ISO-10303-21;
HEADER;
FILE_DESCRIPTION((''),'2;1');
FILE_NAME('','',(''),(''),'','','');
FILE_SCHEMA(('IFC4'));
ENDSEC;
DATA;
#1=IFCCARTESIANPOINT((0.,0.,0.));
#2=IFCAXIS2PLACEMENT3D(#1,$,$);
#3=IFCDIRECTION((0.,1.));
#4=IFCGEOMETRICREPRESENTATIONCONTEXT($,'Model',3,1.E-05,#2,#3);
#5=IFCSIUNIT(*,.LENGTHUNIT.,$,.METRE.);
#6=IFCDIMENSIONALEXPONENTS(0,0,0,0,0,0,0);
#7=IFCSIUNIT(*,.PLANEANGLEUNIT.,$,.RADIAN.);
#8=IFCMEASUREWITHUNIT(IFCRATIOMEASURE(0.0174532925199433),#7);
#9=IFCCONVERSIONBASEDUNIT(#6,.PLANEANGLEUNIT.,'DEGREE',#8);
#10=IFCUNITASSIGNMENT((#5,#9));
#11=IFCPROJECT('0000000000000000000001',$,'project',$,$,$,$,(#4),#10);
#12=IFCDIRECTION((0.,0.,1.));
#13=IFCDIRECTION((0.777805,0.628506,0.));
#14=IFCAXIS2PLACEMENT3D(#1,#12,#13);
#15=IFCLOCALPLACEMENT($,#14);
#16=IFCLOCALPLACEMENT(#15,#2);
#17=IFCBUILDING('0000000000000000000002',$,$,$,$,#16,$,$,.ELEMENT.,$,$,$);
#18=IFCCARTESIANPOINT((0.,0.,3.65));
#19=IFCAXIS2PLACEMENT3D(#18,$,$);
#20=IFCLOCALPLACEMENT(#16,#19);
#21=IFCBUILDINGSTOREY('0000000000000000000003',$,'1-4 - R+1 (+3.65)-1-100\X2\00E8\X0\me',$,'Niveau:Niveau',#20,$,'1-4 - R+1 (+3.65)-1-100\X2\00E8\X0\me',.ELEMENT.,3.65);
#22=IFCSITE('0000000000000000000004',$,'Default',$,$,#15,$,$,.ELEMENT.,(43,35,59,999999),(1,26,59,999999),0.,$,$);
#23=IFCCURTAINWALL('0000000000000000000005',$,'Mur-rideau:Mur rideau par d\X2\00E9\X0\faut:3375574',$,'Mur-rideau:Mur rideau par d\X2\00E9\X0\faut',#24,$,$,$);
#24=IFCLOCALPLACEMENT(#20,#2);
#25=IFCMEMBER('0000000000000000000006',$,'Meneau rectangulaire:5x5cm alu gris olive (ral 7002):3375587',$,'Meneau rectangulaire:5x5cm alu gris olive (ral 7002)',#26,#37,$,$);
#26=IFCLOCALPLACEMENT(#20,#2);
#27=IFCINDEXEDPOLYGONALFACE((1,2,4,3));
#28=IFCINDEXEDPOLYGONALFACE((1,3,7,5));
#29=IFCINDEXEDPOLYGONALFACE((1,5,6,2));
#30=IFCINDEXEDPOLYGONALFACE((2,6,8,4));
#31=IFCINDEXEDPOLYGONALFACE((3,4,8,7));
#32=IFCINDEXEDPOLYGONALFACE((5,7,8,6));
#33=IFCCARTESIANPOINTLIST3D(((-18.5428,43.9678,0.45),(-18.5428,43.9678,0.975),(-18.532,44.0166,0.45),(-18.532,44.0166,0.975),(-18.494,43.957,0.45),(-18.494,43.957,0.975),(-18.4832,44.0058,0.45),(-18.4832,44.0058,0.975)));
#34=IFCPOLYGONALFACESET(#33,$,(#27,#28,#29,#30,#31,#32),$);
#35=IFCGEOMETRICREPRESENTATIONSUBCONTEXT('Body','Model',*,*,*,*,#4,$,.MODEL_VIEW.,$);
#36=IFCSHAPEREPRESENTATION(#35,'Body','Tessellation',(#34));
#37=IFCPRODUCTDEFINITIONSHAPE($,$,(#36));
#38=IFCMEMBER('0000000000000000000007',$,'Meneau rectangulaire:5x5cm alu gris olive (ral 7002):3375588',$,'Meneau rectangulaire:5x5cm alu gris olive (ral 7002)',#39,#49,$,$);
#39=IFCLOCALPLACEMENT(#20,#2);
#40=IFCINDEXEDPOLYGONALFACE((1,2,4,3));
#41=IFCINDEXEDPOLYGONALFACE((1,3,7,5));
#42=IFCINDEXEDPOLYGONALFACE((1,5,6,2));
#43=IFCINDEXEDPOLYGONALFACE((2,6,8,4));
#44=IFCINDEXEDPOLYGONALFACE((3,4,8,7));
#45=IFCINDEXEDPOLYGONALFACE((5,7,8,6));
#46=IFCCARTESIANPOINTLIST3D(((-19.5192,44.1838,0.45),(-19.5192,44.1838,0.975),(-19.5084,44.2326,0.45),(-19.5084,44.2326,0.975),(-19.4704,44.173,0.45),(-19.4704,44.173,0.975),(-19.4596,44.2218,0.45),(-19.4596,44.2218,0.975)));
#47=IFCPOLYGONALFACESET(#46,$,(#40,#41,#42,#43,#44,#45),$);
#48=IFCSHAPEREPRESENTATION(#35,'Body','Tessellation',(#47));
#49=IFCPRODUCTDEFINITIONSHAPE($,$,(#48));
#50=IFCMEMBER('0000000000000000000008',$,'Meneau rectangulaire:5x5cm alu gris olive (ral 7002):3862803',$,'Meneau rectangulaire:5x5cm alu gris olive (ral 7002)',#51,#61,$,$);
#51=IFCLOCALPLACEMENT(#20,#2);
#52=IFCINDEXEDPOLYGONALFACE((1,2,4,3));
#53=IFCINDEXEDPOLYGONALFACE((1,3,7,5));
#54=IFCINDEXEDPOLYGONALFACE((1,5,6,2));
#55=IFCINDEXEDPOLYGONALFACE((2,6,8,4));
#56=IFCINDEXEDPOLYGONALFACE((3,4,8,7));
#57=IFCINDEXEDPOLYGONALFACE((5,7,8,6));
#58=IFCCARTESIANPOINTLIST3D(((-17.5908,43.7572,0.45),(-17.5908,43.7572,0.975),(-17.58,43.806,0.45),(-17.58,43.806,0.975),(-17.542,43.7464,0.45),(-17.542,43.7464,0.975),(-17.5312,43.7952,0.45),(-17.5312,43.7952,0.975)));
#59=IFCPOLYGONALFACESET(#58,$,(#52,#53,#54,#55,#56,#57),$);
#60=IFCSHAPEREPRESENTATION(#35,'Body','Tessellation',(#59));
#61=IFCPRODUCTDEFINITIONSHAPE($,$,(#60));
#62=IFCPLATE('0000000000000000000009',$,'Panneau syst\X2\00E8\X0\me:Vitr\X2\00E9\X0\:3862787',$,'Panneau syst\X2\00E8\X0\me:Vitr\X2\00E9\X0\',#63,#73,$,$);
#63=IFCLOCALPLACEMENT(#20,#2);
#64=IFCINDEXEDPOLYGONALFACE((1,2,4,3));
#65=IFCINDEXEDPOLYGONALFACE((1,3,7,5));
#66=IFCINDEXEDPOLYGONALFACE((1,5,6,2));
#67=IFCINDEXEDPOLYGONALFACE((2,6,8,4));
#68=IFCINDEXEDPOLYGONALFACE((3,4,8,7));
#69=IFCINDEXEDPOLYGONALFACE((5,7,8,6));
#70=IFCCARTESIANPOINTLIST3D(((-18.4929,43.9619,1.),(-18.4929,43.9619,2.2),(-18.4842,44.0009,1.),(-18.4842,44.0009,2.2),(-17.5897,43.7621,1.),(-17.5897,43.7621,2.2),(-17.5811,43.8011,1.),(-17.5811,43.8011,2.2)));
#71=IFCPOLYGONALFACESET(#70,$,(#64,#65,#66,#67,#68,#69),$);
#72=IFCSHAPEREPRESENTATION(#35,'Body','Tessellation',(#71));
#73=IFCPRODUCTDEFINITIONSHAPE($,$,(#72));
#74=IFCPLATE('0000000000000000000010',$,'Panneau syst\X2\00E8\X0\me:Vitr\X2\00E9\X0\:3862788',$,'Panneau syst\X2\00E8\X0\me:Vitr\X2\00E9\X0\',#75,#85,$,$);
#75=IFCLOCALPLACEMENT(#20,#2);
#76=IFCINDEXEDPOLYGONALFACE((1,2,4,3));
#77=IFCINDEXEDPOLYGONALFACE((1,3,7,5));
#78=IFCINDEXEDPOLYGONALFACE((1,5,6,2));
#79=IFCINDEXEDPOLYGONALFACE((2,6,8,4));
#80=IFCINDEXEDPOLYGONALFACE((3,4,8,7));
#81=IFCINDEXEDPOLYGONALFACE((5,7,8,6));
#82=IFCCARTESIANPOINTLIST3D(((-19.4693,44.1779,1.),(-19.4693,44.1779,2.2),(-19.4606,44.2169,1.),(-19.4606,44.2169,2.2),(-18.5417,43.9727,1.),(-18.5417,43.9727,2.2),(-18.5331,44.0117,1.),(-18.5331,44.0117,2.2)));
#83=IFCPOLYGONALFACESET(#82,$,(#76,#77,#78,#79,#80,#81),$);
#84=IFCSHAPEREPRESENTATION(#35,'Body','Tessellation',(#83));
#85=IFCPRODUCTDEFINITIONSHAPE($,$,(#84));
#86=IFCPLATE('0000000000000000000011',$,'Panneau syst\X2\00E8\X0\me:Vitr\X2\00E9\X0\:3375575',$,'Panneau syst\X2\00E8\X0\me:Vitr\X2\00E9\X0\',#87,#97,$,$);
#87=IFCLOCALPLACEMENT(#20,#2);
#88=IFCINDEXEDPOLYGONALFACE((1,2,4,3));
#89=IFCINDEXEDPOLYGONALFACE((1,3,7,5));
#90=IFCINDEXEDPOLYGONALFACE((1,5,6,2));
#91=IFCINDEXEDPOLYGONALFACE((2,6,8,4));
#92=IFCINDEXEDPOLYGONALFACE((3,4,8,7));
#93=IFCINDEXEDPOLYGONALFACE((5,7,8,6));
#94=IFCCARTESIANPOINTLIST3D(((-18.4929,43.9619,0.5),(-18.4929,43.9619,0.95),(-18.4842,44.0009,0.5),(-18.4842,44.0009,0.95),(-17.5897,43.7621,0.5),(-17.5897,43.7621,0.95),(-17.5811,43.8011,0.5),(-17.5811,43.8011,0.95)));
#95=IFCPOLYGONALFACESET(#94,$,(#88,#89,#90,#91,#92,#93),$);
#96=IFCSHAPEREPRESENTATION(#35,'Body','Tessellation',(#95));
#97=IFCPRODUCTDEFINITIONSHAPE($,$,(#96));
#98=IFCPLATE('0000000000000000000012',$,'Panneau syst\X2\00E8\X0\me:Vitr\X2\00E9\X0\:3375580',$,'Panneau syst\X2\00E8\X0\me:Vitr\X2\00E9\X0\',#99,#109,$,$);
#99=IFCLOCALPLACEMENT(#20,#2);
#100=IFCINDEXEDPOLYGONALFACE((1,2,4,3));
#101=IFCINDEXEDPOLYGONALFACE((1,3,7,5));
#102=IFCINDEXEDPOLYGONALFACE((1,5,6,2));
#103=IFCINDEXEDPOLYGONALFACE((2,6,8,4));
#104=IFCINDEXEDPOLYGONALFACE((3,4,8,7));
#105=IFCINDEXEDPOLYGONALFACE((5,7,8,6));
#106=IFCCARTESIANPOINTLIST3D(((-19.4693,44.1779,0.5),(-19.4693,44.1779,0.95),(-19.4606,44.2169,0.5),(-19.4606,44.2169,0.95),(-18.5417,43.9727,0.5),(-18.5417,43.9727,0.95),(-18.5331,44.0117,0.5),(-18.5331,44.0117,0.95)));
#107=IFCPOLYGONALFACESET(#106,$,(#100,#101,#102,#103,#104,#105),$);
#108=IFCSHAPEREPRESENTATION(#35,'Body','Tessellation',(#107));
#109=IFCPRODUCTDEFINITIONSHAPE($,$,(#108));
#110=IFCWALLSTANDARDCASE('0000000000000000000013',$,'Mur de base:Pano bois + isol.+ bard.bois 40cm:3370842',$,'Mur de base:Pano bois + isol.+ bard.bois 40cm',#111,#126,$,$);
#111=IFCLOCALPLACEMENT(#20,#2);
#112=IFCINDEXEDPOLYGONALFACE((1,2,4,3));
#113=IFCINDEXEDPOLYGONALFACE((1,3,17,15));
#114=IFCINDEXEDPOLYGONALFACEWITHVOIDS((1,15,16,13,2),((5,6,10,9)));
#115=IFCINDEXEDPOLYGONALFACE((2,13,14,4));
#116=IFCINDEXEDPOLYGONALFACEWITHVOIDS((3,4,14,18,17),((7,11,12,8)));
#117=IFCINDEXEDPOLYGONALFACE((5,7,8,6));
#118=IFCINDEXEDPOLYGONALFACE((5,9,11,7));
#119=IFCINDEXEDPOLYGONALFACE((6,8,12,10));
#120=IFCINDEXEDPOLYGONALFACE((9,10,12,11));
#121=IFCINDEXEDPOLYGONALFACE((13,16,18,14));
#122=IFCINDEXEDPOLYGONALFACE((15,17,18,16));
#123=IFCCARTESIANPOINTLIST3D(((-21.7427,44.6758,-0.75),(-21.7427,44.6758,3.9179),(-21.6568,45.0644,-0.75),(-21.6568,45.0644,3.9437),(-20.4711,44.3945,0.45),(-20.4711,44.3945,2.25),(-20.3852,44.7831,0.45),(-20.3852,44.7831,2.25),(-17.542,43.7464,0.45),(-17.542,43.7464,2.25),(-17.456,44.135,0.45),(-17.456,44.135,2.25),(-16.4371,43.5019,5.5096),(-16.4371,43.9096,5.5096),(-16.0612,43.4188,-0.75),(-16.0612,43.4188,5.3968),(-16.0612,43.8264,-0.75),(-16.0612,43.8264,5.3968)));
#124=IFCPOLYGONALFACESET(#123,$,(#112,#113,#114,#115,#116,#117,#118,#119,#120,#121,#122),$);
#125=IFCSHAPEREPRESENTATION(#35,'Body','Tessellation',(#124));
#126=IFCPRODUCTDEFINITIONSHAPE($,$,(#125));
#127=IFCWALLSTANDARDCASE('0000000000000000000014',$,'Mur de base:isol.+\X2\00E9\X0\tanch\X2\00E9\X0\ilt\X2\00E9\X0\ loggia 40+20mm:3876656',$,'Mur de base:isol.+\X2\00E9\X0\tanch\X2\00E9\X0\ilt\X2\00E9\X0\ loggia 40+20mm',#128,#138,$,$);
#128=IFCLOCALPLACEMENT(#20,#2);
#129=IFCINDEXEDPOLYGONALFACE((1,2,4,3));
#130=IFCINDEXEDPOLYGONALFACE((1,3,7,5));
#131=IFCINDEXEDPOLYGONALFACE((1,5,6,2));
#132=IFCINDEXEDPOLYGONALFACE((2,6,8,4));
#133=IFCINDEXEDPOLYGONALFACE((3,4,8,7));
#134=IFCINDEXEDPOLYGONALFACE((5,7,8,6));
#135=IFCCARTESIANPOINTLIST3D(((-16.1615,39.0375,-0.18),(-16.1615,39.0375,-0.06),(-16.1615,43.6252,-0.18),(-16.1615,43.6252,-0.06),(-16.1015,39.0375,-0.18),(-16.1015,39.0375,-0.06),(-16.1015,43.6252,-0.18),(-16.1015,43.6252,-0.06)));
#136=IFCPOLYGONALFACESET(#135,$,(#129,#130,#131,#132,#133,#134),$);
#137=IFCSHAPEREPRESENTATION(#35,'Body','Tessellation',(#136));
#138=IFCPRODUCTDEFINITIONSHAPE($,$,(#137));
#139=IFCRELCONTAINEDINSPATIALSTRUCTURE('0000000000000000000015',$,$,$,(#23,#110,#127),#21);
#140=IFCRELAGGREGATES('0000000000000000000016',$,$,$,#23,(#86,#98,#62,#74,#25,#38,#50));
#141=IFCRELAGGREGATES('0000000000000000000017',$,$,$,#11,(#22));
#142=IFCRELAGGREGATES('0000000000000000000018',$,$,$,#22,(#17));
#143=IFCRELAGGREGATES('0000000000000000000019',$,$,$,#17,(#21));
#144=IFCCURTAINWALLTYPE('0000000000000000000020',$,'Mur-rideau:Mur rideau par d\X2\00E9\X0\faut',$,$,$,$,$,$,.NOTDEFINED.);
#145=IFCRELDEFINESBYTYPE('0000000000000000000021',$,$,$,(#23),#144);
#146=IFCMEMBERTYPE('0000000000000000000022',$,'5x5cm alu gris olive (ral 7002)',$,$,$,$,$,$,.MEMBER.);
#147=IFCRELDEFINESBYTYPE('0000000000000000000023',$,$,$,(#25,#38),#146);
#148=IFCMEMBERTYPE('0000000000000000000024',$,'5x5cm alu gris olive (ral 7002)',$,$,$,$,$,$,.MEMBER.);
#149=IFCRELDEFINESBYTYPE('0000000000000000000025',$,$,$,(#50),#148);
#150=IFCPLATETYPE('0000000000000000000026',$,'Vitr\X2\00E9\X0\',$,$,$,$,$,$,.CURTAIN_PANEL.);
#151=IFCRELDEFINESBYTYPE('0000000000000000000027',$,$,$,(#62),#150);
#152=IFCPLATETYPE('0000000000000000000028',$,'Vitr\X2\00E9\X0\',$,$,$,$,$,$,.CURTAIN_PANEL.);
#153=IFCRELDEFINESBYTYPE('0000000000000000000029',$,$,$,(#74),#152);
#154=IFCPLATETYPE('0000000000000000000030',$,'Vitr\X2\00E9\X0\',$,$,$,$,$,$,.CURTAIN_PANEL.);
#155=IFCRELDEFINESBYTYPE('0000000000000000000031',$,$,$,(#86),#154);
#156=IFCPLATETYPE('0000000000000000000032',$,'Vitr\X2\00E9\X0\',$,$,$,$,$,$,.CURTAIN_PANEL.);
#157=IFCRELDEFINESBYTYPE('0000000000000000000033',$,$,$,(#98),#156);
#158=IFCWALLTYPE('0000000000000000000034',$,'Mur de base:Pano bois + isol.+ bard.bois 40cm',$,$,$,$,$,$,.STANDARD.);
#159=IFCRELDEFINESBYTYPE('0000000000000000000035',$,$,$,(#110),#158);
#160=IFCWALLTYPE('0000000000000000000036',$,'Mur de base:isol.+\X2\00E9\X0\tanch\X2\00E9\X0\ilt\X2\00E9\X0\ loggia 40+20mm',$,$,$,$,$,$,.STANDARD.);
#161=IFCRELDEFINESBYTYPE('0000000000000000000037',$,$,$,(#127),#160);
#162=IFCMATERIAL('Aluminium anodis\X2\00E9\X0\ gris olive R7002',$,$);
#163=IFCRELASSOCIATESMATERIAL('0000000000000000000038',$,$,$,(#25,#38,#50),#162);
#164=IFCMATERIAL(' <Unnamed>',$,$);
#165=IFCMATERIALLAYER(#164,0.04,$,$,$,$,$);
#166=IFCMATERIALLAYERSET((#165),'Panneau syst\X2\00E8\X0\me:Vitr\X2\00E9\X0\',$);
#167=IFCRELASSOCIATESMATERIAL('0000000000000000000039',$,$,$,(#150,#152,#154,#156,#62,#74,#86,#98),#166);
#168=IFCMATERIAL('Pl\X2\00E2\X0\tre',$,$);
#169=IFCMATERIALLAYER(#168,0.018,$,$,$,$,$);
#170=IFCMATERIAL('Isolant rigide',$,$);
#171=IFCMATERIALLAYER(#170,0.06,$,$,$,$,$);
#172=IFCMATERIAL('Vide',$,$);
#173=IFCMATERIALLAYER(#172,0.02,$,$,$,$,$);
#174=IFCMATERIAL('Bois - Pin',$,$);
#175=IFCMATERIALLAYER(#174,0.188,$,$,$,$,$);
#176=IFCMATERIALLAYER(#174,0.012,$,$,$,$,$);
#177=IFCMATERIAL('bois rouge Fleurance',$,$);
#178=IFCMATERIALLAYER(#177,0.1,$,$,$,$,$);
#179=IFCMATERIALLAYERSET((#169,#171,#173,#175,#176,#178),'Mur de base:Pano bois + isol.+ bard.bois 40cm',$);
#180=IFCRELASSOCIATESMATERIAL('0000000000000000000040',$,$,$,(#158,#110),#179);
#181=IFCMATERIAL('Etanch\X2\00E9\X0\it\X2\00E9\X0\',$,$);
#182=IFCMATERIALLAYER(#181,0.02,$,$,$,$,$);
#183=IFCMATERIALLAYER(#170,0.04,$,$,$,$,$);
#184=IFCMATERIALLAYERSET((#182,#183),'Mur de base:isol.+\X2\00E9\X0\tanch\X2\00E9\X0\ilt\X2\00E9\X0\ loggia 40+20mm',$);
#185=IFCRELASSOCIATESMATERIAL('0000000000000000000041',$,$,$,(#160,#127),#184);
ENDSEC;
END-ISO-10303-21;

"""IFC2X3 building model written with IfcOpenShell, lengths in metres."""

from ifc_helpers import new_model, entity, si_unit, converted_unit, direction, frame, frame_2d, origin, origin_2d_with_axis, place, context, subcontext, project, spatial, polyline, rectangle, outline, extrude, clip, bounded_halfspace, source, transform, mapped, material, layer, layer_set, layer_usage, type_object, type_shapes, element, aggregate, save


model = new_model("IFC2X3")

# Units and contexts
model_context = context("Model", 3, precision=1e-05, world=origin(), true_north=direction((0.0, 1.0)))
body_context = subcontext(model_context, "Body", "Model", "MODEL_VIEW")
ifc_project = project(units=[si_unit("LENGTHUNIT", "METRE"), converted_unit("PLANEANGLEUNIT", "DEGREE", entity("IfcRatioMeasure", 0.0174532925199433), si_unit("PLANEANGLEUNIT", "RADIAN"), dimensions=[0, 0, 0, 0, 0, 0, 0])], contexts=[model_context])

# Site, building, storey
site_placement = place(None, frame((0.0, 0.0, 0.0), z_axis=(0.0, 0.0, 1.0), x_axis=(0.777805, 0.628506, 0.0)))
site = spatial("IfcSite", under=ifc_project, at=site_placement, Name="Default", CompositionType="ELEMENT", RefLatitude=(43, 35, 59, 999999), RefLongitude=(1, 26, 59, 999999), RefElevation=0.0)
building_placement = place(site_placement, origin())
building = spatial("IfcBuilding", under=site, at=building_placement, CompositionType="ELEMENT")
storey_placement = place(building_placement, frame((0.0, 0.0, 3.65)))
storey = spatial("IfcBuildingStorey", under=building, at=storey_placement, Name="1-4 - R+1 (+3.65)-1-100ème", ObjectType="Niveau:Niveau", LongName="1-4 - R+1 (+3.65)-1-100ème", CompositionType="ELEMENT", Elevation=3.65)

# Shared definitions
curtain_wall_type = type_object("IfcCurtainWallType", Name="Mur-rideau:Mur rideau par défaut", PredefinedType="NOTDEFINED")
ifc_material_1 = material(Name="Aluminium anodisé gris olive R7002")

# Curtain wall, members, plates
curtain_wall_1_placement = place(storey_placement, frame((0.0, 0.0, -3.65)))
curtain_wall_1 = element("IfcCurtainWall", 1, at=curtain_wall_1_placement, inside=storey, type_object=curtain_wall_type, Name="Mur-rideau:Mur rideau par défaut:3375574", ObjectType="Mur-rideau:Mur rideau par défaut")
member_type_1 = type_object("IfcMemberType", Name="5x5cm alu gris olive (ral 7002)", PredefinedType="MEMBER")
shared_shape_1 = source(origin(), body_context, "Body", "SweptSolid", [
    extrude(rectangle(XDim=0.05, YDim=0.05, at=origin_2d_with_axis()), frame((0.0, 0.0, -0.525), z_axis=(0.0, 0.0, 1.0), x_axis=(0.0, -1.0, 0.0)), (0.0, 0.0, 1.0), 0.525),
])
type_shapes(member_type_1, [shared_shape_1])
member_1_placement = place(storey_placement, frame((-18.513, 43.9868, 0.45), z_axis=(0.0, 0.0, -1.0), x_axis=(-0.976392, 0.216005, 0.0)))
member_1 = element("IfcMember", 2, at=member_1_placement, type_object=member_type_1, material=ifc_material_1, Name="Meneau rectangulaire:5x5cm alu gris olive (ral 7002):3375587", ObjectType="Meneau rectangulaire:5x5cm alu gris olive (ral 7002)", context=body_context, shape_type="MappedRepresentation", body=[
    mapped(shared_shape_1, transform((0.0, 0.0, 0.0), scale=1.0)),
])
member_2_placement = place(storey_placement, frame((-19.4894, 44.2028, 0.45), z_axis=(0.0, 0.0, -1.0), x_axis=(-0.976392, 0.216005, 0.0)))
member_2 = element("IfcMember", 3, at=member_2_placement, type_object=member_type_1, material=ifc_material_1, Name="Meneau rectangulaire:5x5cm alu gris olive (ral 7002):3375588", ObjectType="Meneau rectangulaire:5x5cm alu gris olive (ral 7002)", context=body_context, shape_type="MappedRepresentation", body=[
    mapped(shared_shape_1, transform((0.0, 0.0, 0.0), scale=1.0)),
])
member_type_2 = type_object("IfcMemberType", Name="5x5cm alu gris olive (ral 7002)", PredefinedType="MEMBER")
shared_shape_2 = source(origin(), body_context, "Body", "SweptSolid", [
    extrude(rectangle(XDim=0.05, YDim=0.05, at=origin_2d_with_axis()), frame((-0.025, 0.0, -0.525), z_axis=(0.0, 0.0, 1.0), x_axis=(0.0, -1.0, 0.0)), (0.0, 0.0, 1.0), 0.525),
])
type_shapes(member_type_2, [shared_shape_2])
member_3_placement = place(storey_placement, frame((-17.5366, 43.7708, 0.975), z_axis=(0.0, 0.0, 1.0), x_axis=(0.976392, -0.216005, 0.0)))
member_3 = element("IfcMember", 4, at=member_3_placement, type_object=member_type_2, material=ifc_material_1, Name="Meneau rectangulaire:5x5cm alu gris olive (ral 7002):3862803", ObjectType="Meneau rectangulaire:5x5cm alu gris olive (ral 7002)", context=body_context, shape_type="MappedRepresentation", body=[
    mapped(shared_shape_2, transform((0.0, 0.0, 0.0), scale=1.0)),
])
ifc_material_2 = material(Name=" <Unnamed>")
ifc_layer_1 = layer(ifc_material_2, 0.04)
ifc_layer_set_1 = layer_set([ifc_layer_1], Name="Panneau système:Vitré")
ifc_layer_usage_1 = layer_usage(ifc_layer_set_1, "AXIS3", "POSITIVE", 0.0)
plate_type_1 = type_object("IfcPlateType", Name="Vitré", PredefinedType="CURTAIN_PANEL", material=ifc_layer_set_1)
shared_shape_3 = source(origin(), body_context, "Body", "SweptSolid", [
    extrude(rectangle(XDim=0.04, YDim=0.925, at=frame_2d((0.0, 0.0), x_axis=(1.0, 0.0))), frame((0.0, 0.0, 0.0), z_axis=(0.0, 0.0, 1.0), x_axis=(0.0, 1.0, 0.0)), (0.0, 0.0, 1.0), 1.2),
])
type_shapes(plate_type_1, [shared_shape_3])
plate_1_placement = place(curtain_wall_1_placement, frame((-18.037, 43.8815, 4.65), z_axis=(0.0, 0.0, 1.0), x_axis=(-0.976392, 0.216005, 0.0)))
plate_1 = element("IfcPlate", 5, at=plate_1_placement, type_object=plate_type_1, material=ifc_layer_usage_1, Name="Panneau système:Vitré:3862787", ObjectType="Panneau système:Vitré", context=body_context, shape_type="MappedRepresentation", body=[
    mapped(shared_shape_3, transform((0.0, 0.0, 0.0), scale=1.0)),
])
ifc_layer_usage_2 = layer_usage(ifc_layer_set_1, "AXIS3", "POSITIVE", 0.0)
plate_type_2 = type_object("IfcPlateType", Name="Vitré", PredefinedType="CURTAIN_PANEL", material=ifc_layer_set_1)
shared_shape_4 = source(origin(), body_context, "Body", "SweptSolid", [
    extrude(rectangle(XDim=0.04, YDim=0.95, at=frame_2d((0.0, 0.0), x_axis=(1.0, 0.0))), frame((0.0, 0.0, 0.0), z_axis=(0.0, 0.0, 1.0), x_axis=(0.0, 1.0, 0.0)), (0.0, 0.0, 1.0), 1.2),
])
type_shapes(plate_type_2, [shared_shape_4])
plate_2_placement = place(curtain_wall_1_placement, frame((-19.0012, 44.0948, 4.65), z_axis=(0.0, 0.0, 1.0), x_axis=(-0.976392, 0.216005, 0.0)))
plate_2 = element("IfcPlate", 6, at=plate_2_placement, type_object=plate_type_2, material=ifc_layer_usage_2, Name="Panneau système:Vitré:3862788", ObjectType="Panneau système:Vitré", context=body_context, shape_type="MappedRepresentation", body=[
    mapped(shared_shape_4, transform((0.0, 0.0, 0.0), scale=1.0)),
])
ifc_layer_usage_3 = layer_usage(ifc_layer_set_1, "AXIS3", "POSITIVE", 0.0)
plate_type_3 = type_object("IfcPlateType", Name="Vitré", PredefinedType="CURTAIN_PANEL", material=ifc_layer_set_1)
shared_shape_5 = source(origin(), body_context, "Body", "SweptSolid", [
    extrude(rectangle(XDim=0.04, YDim=0.925, at=frame_2d((0.0, 0.0), x_axis=(1.0, 0.0))), frame((0.0, 0.0, 0.0), z_axis=(0.0, 0.0, 1.0), x_axis=(0.0, 1.0, 0.0)), (0.0, 0.0, 1.0), 0.45),
])
type_shapes(plate_type_3, [shared_shape_5])
plate_3_placement = place(curtain_wall_1_placement, frame((-18.037, 43.8815, 4.15), z_axis=(0.0, 0.0, 1.0), x_axis=(-0.976392, 0.216005, 0.0)))
plate_3 = element("IfcPlate", 7, at=plate_3_placement, type_object=plate_type_3, material=ifc_layer_usage_3, Name="Panneau système:Vitré:3375575", ObjectType="Panneau système:Vitré", context=body_context, shape_type="MappedRepresentation", body=[
    mapped(shared_shape_5, transform((0.0, 0.0, 0.0), scale=1.0)),
])
ifc_layer_usage_4 = layer_usage(ifc_layer_set_1, "AXIS3", "POSITIVE", 0.0)
plate_type_4 = type_object("IfcPlateType", Name="Vitré", PredefinedType="CURTAIN_PANEL", material=ifc_layer_set_1)
shared_shape_6 = source(origin(), body_context, "Body", "SweptSolid", [
    extrude(rectangle(XDim=0.04, YDim=0.95, at=frame_2d((0.0, 0.0), x_axis=(1.0, 0.0))), frame((0.0, 0.0, 0.0), z_axis=(0.0, 0.0, 1.0), x_axis=(0.0, 1.0, 0.0)), (0.0, 0.0, 1.0), 0.45),
])
type_shapes(plate_type_4, [shared_shape_6])
plate_4_placement = place(curtain_wall_1_placement, frame((-19.0012, 44.0948, 4.15), z_axis=(0.0, 0.0, 1.0), x_axis=(-0.976392, 0.216005, 0.0)))
plate_4 = element("IfcPlate", 8, at=plate_4_placement, type_object=plate_type_4, material=ifc_layer_usage_4, Name="Panneau système:Vitré:3375580", ObjectType="Panneau système:Vitré", context=body_context, shape_type="MappedRepresentation", body=[
    mapped(shared_shape_6, transform((0.0, 0.0, 0.0), scale=1.0)),
])
aggregate(curtain_wall_1, [plate_3, plate_4, plate_1, plate_2, member_1, member_2, member_3])

# Wall, opening
ifc_material_3 = material(Name="Plâtre")
ifc_layer_2 = layer(ifc_material_3, 0.018)
ifc_material_4 = material(Name="Isolant rigide")
ifc_layer_3 = layer(ifc_material_4, 0.06)
ifc_material_5 = material(Name="Vide")
ifc_layer_4 = layer(ifc_material_5, 0.02)
ifc_material_6 = material(Name="Bois - Pin")
ifc_layer_5 = layer(ifc_material_6, 0.188)
ifc_layer_6 = layer(ifc_material_6, 0.012)
ifc_material_7 = material(Name="bois rouge Fleurance")
ifc_layer_7 = layer(ifc_material_7, 0.1)
ifc_layer_set_2 = layer_set([ifc_layer_2, ifc_layer_3, ifc_layer_4, ifc_layer_5, ifc_layer_6, ifc_layer_7], Name="Mur de base:Pano bois + isol.+ bard.bois 40cm")
ifc_layer_usage_5 = layer_usage(ifc_layer_set_2, "AXIS2", "NEGATIVE", 0.199)
wall_type_1 = type_object("IfcWallType", Name="Mur de base:Pano bois + isol.+ bard.bois 40cm", PredefinedType="STANDARD", material=ifc_layer_set_2)
wall_1_placement = place(storey_placement, frame((-16.0182, 43.6131, -0.75), z_axis=(0.0, 0.0, 1.0), x_axis=(-0.976388, 0.216025, 0.0)))
wall_1 = element("IfcWallStandardCase", 9, at=wall_1_placement, inside=storey, type_object=wall_type_1, material=ifc_layer_usage_5, Name="Mur de base:Pano bois + isol.+ bard.bois 40cm:3370842", ObjectType="Mur de base:Pano bois + isol.+ bard.bois 40cm", context=body_context, shape_type="Clipping", body=[
    clip(clip(extrude(outline(polyline([(5.819, -0.199), (5.819, 0.199), (0.0, 0.199), (0.0881, -0.199), (5.819, -0.199)])), origin(), (0.0, 0.0, 1.0), 6.2596), bounded_halfspace(frame((5.819, -0.199, 4.6937), z_axis=(0.280563, 0.062074, 0.957826), x_axis=(-0.216025, 0.976388, 0.0)), False, frame((5.819, -0.199, 4.6937)), polyline([(0.0, 0.0), (0.0, 0.398), (-5.3448, 0.398), (-5.3882, 0.398), (-5.4295, 0.398), (-5.434, 0.398), (-5.3459, 0.0), (0.0, 0.0)]))), bounded_halfspace(frame((0.0, 0.199, 6.1468), z_axis=(-0.280563, -0.062074, 0.957826), x_axis=(0.216025, -0.976388, 0.0)), False, frame((0.0, 0.199, 6.1468)), polyline([(0.0, 0.0), (0.0881, -0.398), (0.4731, -0.398), (0.385, 0.0), (0.3805, 0.0), (0.3304, 0.0), (0.3073, 0.0), (0.0, 0.0)]))),
])
opening_1_placement = place(wall_1_placement, origin())
element("IfcOpeningElement", 10, at=opening_1_placement, cuts=wall_1, ObjectType="Opening", context=body_context, shape_type="SweptSolid", body=[
    extrude(rectangle(XDim=1.8, YDim=3.0, at=frame_2d((0.0, 0.0), x_axis=(1.0, 0.0))), frame((3.0166, -0.3514, 2.1), z_axis=(0.0, 1.0, 0.0), x_axis=(0.0, 0.0, 1.0)), (0.0, 0.0, 1.0), 0.7028),
])

# Wall
ifc_material_8 = material(Name="Etanchéité")
ifc_layer_8 = layer(ifc_material_8, 0.02)
ifc_layer_9 = layer(ifc_material_4, 0.04)
ifc_layer_set_3 = layer_set([ifc_layer_8, ifc_layer_9], Name="Mur de base:isol.+étanchéilté loggia 40+20mm")
ifc_layer_usage_6 = layer_usage(ifc_layer_set_3, "AXIS2", "NEGATIVE", 0.03)
wall_type_2 = type_object("IfcWallType", Name="Mur de base:isol.+étanchéilté loggia 40+20mm", PredefinedType="STANDARD", material=ifc_layer_set_3)
wall_2_placement = place(storey_placement, frame((-16.1315, 43.6252, -0.18), z_axis=(0.0, 0.0, 1.0), x_axis=(0.0, -1.0, 0.0)))
element("IfcWallStandardCase", 11, at=wall_2_placement, inside=storey, type_object=wall_type_2, material=ifc_layer_usage_6, Name="Mur de base:isol.+étanchéilté loggia 40+20mm:3876656", ObjectType="Mur de base:isol.+étanchéilté loggia 40+20mm", context=body_context, shape_type="SweptSolid", body=[
    extrude(rectangle(XDim=4.5878, YDim=0.06, at=frame_2d((2.2939, 0.0), x_axis=(-1.0, 0.0))), origin(), (0.0, 0.0, 1.0), 0.12),
])

save(model, "model.ifc")
